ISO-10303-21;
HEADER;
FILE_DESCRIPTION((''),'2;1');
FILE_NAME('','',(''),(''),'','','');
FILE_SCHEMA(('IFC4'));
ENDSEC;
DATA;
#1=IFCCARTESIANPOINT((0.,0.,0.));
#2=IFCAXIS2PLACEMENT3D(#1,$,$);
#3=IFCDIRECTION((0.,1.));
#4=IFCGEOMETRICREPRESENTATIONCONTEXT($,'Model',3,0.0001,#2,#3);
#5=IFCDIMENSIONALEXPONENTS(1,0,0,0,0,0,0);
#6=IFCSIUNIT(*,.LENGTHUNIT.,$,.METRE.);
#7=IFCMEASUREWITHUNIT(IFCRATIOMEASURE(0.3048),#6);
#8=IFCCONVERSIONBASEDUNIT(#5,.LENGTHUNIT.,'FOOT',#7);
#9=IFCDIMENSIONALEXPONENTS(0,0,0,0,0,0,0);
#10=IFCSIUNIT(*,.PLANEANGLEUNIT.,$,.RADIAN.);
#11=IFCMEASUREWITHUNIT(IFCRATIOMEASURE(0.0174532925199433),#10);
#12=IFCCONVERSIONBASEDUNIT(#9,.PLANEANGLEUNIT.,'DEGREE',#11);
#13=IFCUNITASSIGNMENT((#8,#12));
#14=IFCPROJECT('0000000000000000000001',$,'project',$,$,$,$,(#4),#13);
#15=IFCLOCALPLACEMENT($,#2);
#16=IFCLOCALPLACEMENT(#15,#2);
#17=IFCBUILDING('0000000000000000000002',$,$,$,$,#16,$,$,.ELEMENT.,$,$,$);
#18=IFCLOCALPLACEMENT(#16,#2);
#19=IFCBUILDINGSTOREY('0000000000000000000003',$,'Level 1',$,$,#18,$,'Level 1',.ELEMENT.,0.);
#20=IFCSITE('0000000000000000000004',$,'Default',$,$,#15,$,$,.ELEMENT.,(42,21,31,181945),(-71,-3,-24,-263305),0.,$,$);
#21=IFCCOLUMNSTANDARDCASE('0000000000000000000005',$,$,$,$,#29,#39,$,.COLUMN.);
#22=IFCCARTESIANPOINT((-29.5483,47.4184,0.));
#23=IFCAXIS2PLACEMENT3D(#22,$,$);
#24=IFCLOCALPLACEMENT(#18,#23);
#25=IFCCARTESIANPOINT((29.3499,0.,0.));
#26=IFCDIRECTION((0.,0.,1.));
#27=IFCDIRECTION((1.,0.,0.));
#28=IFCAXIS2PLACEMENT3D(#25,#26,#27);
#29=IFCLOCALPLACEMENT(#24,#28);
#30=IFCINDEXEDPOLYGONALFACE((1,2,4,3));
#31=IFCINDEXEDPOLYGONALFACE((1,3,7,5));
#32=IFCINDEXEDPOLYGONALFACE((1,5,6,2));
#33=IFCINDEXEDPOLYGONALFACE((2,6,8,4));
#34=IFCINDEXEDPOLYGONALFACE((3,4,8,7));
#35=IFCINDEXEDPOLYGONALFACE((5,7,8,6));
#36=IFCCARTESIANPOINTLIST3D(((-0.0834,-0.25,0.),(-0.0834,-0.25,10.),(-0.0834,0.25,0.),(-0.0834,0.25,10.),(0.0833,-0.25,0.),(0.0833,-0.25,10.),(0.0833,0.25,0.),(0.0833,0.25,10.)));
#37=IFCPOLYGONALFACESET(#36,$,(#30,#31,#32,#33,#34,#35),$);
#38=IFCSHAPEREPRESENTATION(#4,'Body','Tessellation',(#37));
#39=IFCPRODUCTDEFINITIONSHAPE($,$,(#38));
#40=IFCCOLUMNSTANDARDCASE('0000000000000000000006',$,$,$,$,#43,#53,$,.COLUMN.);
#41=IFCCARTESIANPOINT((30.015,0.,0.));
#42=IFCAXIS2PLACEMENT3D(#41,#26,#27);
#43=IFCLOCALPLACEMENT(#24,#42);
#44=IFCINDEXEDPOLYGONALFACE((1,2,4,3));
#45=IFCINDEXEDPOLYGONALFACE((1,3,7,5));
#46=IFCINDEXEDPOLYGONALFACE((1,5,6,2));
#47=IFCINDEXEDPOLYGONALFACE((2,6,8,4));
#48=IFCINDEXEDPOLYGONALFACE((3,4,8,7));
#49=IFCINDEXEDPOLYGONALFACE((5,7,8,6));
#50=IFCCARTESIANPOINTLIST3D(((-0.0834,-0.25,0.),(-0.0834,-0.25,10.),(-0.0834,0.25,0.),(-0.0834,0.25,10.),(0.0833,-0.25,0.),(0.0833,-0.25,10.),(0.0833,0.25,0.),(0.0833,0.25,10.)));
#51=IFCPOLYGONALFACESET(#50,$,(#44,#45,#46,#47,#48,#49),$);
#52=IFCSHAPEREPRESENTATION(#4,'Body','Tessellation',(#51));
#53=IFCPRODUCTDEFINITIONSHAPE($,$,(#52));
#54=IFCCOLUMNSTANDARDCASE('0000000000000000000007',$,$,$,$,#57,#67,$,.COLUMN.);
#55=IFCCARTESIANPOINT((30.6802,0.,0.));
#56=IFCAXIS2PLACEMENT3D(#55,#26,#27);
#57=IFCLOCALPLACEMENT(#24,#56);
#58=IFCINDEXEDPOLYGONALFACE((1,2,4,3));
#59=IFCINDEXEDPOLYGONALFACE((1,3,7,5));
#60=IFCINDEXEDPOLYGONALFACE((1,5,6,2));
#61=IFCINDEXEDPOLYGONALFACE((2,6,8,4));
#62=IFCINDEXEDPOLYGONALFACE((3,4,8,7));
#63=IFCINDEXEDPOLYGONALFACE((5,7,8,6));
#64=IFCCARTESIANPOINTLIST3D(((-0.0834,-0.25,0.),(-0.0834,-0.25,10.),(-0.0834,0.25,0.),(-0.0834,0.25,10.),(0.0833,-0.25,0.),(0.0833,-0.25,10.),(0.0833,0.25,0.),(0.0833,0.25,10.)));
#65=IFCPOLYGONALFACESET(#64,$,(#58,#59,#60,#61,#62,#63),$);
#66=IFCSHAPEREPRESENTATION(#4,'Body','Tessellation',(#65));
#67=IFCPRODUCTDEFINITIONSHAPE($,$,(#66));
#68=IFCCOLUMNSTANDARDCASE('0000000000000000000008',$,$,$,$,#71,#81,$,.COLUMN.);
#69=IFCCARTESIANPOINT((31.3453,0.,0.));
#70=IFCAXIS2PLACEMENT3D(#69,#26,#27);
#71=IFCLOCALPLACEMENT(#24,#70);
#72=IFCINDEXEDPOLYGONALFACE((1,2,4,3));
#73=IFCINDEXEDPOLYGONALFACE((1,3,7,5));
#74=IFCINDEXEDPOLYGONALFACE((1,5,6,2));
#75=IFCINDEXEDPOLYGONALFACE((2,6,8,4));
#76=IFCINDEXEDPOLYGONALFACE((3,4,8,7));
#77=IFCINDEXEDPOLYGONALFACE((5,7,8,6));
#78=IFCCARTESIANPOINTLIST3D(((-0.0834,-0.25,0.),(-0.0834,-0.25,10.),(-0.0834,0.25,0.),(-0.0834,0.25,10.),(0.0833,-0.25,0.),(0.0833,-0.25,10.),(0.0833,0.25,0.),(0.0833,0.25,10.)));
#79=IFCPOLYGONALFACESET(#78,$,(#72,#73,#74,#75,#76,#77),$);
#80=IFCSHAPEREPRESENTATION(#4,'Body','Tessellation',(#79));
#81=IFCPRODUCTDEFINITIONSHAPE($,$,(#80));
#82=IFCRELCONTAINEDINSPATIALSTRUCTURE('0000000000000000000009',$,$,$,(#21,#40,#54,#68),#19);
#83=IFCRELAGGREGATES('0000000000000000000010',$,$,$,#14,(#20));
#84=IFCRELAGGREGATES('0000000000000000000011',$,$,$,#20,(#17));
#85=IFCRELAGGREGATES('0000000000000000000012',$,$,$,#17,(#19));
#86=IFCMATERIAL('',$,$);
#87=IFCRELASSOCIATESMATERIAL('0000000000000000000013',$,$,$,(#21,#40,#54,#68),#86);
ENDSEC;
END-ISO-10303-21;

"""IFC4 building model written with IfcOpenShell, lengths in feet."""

from ifc_helpers import new_model, entity, si_unit, converted_unit, direction, frame, origin, place, context, project, spatial, rectangle, extrude, material, element, save


model = new_model("IFC4")

# Units and contexts
model_context = context("Model", 3, precision=0.0001, world=origin(), true_north=direction((0.0, 1.0)))
ifc_project = project(units=[converted_unit("LENGTHUNIT", "FOOT", entity("IfcRatioMeasure", 0.3048), si_unit("LENGTHUNIT", "METRE"), dimensions=[1, 0, 0, 0, 0, 0, 0]), converted_unit("PLANEANGLEUNIT", "DEGREE", entity("IfcRatioMeasure", 0.0174532925199433), si_unit("PLANEANGLEUNIT", "RADIAN"), dimensions=[0, 0, 0, 0, 0, 0, 0])], contexts=[model_context])

# Site, building, storey
site_placement = place(None, origin())
site = spatial("IfcSite", under=ifc_project, at=site_placement, Name="Default", CompositionType="ELEMENT", RefLatitude=(42, 21, 31, 181945), RefLongitude=(-71, -3, -24, -263305), RefElevation=0.0)
building_placement = place(site_placement, origin())
building = spatial("IfcBuilding", under=site, at=building_placement, CompositionType="ELEMENT")
storey_placement = place(building_placement, origin())
storey = spatial("IfcBuildingStorey", under=building, at=storey_placement, Name="Level 1", LongName="Level 1", CompositionType="ELEMENT", Elevation=0.0)

# Columns
ifc_material = material(Name="")
placement = place(storey_placement, frame((-29.5483, 47.4184, 0.0)))
for number, where, z_axis, x_axis in (
    (1, (29.3499, 0.0, 0.0), (0.0, 0.0, 1.0), (1.0, 0.0, 0.0)),
    (2, (30.015, 0.0, 0.0), (0.0, 0.0, 1.0), (1.0, 0.0, 0.0)),
    (3, (30.6802, 0.0, 0.0), (0.0, 0.0, 1.0), (1.0, 0.0, 0.0)),
    (4, (31.3453, 0.0, 0.0), (0.0, 0.0, 1.0), (1.0, 0.0, 0.0)),
):
    element("IfcColumnStandardCase", number, at=place(placement, frame(where, z_axis=z_axis, x_axis=x_axis)), inside=storey, material=ifc_material, PredefinedType="COLUMN", context=model_context, shape_type="SweptSolid", body=[
        extrude(rectangle(XDim=0.1667, YDim=0.5), origin(), (0.0, 0.0, 1.0), 10.0),
    ])

save(model, "model.ifc")
